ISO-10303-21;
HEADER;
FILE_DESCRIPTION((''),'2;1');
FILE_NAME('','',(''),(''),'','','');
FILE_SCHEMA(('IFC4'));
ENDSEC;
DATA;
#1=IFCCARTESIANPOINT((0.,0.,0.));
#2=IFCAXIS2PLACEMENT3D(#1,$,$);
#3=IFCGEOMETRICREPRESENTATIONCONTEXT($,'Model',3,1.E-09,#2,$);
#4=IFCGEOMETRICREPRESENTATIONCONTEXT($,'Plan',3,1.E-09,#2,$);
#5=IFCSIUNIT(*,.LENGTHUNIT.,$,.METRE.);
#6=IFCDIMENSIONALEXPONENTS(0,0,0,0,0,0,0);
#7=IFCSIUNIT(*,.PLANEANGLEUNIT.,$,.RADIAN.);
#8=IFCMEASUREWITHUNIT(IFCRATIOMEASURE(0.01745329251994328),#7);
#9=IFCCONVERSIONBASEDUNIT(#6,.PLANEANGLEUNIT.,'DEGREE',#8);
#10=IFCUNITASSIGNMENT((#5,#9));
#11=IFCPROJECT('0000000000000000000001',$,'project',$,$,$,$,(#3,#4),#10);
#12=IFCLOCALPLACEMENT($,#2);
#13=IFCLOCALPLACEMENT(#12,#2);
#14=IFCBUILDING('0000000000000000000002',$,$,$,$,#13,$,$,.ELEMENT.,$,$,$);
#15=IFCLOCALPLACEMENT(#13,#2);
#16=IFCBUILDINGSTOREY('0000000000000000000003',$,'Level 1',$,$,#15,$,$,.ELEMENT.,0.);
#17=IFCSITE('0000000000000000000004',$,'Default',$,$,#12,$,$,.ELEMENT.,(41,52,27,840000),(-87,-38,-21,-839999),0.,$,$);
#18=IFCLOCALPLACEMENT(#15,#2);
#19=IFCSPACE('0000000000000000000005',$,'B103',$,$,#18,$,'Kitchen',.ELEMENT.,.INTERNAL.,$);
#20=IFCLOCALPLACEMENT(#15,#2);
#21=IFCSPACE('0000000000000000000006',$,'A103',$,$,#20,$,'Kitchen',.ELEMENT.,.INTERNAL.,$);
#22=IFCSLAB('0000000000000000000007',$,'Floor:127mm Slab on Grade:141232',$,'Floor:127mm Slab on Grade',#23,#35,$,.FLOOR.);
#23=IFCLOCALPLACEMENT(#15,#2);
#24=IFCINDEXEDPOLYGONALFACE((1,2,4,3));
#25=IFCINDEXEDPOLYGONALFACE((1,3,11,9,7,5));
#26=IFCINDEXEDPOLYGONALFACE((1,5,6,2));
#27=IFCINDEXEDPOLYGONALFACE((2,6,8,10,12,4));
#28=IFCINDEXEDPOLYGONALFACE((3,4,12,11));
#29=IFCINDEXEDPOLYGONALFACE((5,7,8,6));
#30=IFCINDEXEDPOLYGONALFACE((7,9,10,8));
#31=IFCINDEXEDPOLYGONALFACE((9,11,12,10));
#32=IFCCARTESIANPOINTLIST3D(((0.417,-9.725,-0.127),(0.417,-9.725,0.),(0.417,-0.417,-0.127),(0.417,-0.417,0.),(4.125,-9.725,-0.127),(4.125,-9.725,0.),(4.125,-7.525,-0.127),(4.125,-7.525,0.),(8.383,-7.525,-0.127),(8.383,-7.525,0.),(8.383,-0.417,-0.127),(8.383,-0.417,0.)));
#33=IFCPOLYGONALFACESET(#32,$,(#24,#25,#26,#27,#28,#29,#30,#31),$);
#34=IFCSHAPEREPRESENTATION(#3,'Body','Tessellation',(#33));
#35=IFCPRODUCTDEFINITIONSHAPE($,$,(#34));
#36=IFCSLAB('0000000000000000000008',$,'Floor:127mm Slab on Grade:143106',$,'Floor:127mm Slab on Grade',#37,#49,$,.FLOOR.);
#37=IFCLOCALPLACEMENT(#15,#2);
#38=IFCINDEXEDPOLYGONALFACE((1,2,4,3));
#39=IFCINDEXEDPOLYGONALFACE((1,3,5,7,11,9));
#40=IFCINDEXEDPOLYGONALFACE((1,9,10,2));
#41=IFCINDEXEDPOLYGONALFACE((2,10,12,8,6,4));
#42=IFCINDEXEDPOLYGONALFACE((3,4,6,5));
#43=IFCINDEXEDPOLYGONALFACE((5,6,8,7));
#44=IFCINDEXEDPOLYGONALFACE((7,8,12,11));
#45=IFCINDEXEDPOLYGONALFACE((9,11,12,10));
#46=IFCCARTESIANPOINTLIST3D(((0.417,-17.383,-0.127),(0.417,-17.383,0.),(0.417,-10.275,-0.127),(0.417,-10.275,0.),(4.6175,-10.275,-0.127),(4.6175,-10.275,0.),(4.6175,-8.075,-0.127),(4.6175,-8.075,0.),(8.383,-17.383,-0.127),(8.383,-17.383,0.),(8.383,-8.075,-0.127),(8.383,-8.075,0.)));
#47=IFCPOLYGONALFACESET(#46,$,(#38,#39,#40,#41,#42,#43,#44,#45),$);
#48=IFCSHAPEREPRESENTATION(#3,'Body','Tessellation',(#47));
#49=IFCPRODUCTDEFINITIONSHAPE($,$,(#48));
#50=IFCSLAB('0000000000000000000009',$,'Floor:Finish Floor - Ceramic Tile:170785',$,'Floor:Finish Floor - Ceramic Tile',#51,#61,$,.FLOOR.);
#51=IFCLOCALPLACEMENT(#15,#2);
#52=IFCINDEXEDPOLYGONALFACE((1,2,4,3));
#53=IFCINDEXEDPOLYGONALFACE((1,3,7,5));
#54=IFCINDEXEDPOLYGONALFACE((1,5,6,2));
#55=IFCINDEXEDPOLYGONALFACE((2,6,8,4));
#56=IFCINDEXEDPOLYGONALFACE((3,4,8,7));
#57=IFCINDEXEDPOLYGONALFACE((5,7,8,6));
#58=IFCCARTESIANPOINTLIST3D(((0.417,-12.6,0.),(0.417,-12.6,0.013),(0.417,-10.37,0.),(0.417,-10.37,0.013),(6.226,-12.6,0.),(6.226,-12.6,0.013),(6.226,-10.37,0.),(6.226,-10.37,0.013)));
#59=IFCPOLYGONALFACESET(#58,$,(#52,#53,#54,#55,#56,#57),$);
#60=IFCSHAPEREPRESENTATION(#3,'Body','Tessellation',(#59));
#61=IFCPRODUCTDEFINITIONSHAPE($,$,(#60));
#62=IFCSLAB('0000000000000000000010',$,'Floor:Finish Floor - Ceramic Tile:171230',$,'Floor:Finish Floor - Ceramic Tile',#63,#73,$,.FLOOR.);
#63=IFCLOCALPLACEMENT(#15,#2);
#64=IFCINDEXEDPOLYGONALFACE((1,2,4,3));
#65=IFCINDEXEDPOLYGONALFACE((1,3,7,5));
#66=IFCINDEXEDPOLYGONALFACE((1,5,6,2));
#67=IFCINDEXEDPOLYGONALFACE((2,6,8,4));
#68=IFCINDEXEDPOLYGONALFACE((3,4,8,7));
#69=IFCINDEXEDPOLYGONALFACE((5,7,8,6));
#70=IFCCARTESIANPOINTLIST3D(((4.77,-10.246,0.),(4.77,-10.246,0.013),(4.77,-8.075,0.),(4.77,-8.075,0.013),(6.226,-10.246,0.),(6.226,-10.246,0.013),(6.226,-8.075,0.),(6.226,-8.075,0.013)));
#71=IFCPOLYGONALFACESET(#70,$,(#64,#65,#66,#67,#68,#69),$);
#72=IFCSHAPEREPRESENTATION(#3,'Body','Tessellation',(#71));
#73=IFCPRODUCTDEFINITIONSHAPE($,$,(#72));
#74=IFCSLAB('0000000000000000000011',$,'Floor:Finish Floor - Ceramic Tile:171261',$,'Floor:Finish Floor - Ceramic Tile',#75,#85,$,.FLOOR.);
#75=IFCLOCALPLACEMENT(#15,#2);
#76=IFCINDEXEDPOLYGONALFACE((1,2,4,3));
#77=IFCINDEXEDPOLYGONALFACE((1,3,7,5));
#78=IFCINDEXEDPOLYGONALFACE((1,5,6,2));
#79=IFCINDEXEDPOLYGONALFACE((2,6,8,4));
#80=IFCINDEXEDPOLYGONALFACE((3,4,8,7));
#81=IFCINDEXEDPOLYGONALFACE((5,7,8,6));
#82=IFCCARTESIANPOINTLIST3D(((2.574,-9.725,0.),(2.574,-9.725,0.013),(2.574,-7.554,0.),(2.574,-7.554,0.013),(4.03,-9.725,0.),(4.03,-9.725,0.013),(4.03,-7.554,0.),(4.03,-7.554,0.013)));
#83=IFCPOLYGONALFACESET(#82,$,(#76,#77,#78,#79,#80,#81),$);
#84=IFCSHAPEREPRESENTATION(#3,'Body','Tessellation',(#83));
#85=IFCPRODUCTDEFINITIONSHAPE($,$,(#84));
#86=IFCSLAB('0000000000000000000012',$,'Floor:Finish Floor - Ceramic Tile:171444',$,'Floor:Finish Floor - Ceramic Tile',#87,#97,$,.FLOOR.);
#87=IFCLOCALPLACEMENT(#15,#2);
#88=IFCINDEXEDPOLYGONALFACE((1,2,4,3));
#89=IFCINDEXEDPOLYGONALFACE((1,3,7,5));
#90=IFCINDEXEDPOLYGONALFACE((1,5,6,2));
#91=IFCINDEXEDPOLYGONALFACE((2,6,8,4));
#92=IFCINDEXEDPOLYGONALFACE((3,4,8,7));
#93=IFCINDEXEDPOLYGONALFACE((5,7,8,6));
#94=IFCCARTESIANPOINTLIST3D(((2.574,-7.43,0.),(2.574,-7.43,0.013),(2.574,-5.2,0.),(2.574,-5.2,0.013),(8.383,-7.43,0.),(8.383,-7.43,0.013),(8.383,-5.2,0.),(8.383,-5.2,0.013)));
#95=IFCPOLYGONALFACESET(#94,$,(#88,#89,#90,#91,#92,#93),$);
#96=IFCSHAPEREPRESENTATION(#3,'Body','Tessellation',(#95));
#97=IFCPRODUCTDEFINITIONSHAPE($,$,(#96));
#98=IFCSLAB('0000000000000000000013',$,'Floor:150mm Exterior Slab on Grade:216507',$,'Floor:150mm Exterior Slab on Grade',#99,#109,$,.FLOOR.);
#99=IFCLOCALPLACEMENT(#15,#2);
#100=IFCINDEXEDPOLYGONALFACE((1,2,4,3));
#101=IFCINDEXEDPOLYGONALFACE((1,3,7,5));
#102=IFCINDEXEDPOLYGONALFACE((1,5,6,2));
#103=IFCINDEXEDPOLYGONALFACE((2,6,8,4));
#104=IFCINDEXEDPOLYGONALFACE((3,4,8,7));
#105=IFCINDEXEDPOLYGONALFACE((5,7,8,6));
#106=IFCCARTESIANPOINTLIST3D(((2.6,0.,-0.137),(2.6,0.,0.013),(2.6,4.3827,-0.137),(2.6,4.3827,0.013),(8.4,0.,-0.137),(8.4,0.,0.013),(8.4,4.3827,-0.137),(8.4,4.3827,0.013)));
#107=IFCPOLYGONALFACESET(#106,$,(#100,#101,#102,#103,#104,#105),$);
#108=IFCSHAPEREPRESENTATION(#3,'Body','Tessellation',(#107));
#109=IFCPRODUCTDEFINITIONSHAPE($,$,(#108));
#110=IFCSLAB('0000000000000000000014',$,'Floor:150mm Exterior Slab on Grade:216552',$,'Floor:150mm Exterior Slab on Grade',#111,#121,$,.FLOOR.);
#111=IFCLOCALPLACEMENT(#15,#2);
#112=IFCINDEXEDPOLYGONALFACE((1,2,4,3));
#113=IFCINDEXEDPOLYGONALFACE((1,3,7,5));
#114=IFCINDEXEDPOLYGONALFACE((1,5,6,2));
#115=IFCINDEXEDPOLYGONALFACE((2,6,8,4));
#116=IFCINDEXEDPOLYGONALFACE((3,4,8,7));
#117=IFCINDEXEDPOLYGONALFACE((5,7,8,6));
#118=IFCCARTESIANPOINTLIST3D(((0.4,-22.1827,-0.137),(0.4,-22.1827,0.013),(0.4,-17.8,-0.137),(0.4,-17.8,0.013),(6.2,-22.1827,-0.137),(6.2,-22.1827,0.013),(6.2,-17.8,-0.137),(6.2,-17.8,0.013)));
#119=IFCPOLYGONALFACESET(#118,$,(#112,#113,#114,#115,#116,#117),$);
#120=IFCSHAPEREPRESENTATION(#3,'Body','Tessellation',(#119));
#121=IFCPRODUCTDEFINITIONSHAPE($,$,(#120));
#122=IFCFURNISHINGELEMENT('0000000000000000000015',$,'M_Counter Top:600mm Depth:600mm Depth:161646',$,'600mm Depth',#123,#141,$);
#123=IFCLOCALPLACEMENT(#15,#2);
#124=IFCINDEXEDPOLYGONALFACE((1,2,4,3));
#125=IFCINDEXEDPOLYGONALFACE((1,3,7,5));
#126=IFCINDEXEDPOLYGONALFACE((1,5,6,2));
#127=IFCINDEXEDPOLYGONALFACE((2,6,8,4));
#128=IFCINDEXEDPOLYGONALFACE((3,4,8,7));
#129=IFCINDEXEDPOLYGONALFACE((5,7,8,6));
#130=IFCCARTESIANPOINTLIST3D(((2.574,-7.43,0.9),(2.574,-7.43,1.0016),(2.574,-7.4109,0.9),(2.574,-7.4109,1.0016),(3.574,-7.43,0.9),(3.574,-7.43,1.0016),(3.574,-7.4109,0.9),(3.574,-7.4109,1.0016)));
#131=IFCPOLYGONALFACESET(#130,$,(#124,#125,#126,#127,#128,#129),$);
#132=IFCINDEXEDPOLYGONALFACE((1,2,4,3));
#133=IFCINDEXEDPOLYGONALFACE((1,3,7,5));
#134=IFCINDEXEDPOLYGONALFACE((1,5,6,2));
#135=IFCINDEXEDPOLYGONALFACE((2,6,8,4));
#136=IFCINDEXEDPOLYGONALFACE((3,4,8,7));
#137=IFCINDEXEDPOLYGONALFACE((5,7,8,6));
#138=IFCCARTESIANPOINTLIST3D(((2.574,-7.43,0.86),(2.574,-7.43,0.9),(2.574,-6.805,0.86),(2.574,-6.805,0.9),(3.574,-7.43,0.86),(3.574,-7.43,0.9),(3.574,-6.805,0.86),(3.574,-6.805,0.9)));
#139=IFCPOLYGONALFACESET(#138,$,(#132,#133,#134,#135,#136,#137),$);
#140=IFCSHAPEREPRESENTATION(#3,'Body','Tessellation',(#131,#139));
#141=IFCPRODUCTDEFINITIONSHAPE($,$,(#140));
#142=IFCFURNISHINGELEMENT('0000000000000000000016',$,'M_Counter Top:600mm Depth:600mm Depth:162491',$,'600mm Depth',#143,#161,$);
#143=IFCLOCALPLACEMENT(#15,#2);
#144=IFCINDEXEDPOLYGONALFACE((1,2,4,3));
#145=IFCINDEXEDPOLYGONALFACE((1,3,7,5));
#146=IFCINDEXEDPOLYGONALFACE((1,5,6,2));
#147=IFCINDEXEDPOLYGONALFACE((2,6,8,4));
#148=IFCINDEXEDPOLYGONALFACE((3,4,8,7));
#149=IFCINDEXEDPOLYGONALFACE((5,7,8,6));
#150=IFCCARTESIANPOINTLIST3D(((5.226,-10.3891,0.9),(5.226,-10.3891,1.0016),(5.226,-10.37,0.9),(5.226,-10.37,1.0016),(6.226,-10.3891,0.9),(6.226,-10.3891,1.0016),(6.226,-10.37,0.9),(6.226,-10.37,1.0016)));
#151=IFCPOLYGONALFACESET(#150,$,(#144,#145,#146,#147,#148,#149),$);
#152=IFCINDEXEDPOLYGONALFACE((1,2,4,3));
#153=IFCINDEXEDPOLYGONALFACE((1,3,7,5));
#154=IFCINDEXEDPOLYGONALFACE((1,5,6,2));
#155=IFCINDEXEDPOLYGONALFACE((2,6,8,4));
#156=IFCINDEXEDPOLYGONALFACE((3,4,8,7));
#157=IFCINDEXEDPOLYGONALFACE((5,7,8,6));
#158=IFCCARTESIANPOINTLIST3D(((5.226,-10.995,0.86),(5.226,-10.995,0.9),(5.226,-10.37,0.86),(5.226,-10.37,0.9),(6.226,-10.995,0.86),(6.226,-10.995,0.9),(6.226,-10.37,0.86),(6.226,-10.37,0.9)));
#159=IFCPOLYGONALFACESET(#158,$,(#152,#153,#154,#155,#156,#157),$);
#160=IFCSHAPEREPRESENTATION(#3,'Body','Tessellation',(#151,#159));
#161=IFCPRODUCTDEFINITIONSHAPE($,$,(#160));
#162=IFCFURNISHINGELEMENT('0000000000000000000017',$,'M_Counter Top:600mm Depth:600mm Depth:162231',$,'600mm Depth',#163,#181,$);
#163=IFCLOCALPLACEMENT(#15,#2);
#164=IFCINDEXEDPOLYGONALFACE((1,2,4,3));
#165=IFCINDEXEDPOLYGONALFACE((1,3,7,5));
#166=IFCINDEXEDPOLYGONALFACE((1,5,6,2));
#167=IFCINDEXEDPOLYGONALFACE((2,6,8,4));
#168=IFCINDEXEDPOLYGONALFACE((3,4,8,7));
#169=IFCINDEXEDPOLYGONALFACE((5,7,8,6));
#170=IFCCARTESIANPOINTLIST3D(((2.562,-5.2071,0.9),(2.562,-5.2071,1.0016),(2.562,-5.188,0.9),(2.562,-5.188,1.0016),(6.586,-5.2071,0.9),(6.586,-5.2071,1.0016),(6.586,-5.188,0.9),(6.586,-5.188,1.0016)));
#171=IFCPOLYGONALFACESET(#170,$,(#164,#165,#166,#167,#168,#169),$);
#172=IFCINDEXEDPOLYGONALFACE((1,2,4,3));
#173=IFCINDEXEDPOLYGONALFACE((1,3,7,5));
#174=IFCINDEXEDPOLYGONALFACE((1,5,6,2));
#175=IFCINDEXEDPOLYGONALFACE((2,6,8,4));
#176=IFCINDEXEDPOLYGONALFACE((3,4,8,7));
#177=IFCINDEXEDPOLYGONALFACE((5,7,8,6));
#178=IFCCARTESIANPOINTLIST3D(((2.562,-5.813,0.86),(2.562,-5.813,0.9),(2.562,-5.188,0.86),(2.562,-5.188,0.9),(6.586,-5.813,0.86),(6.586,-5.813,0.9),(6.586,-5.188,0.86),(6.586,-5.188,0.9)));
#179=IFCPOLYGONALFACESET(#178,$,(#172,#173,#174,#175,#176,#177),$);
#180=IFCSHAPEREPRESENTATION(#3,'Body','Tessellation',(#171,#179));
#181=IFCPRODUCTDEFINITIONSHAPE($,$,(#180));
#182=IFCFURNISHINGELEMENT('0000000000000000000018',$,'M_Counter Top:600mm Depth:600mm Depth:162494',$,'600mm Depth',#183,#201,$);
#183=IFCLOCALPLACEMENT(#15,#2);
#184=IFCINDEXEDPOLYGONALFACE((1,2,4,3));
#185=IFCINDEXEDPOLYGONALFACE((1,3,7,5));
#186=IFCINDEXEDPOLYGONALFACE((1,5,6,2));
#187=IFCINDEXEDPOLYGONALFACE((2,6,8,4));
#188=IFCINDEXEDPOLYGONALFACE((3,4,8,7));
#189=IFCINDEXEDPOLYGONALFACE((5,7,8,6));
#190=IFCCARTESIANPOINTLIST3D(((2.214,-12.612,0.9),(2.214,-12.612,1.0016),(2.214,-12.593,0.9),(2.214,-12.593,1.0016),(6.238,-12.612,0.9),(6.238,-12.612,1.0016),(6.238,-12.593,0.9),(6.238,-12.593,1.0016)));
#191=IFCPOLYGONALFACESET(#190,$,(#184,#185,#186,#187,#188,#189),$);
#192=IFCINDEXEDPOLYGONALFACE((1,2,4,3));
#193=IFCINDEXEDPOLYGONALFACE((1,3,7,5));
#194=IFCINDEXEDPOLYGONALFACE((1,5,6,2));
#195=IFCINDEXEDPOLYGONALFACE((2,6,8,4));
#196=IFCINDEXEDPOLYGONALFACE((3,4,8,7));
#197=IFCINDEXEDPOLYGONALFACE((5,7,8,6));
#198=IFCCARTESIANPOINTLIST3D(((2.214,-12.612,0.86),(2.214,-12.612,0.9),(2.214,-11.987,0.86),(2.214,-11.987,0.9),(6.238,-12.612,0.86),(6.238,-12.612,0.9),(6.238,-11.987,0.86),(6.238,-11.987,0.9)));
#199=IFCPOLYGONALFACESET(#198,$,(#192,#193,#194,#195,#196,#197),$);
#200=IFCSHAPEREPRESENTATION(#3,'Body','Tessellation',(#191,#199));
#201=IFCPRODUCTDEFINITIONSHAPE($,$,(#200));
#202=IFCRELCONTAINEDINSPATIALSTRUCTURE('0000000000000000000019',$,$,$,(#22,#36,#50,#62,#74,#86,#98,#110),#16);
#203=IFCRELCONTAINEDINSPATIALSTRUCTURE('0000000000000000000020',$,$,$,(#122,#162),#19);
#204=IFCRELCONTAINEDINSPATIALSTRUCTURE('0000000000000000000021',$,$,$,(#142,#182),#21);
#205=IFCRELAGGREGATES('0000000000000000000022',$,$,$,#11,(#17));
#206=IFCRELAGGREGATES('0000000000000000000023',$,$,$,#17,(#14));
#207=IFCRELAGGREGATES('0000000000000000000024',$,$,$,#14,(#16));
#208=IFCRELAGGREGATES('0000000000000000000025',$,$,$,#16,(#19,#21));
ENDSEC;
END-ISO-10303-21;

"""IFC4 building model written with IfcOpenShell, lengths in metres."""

from ifc_helpers import new_model, entity, si_unit, converted_unit, frame, frame_2d, origin, origin_2d_with_axis, place, context, project, spatial, polyline, rectangle, outline, extrude, source, transform, mapped, element, save


model = new_model("IFC4")

# Units and contexts
model_context = context("Model", 3, precision=1e-09, world=origin())
plan_context = context("Plan", 3, precision=1e-09, world=origin())
ifc_project = project(units=[si_unit("LENGTHUNIT", "METRE"), converted_unit("PLANEANGLEUNIT", "DEGREE", entity("IfcRatioMeasure", 0.01745329251994328), si_unit("PLANEANGLEUNIT", "RADIAN"), dimensions=[0, 0, 0, 0, 0, 0, 0])], contexts=[model_context, plan_context])

# Site, building, storey
site_placement = place(None, origin())
site = spatial("IfcSite", under=ifc_project, at=site_placement, Name="Default", CompositionType="ELEMENT", RefLatitude=(41, 52, 27, 840000), RefLongitude=(-87, -38, -21, -839999), RefElevation=0.0)
building_placement = place(site_placement, origin())
building = spatial("IfcBuilding", under=site, at=building_placement, CompositionType="ELEMENT")
storey_placement = place(building_placement, origin())
storey = spatial("IfcBuildingStorey", under=building, at=storey_placement, Name="Level 1", CompositionType="ELEMENT", Elevation=0.0)

# Slabs
slab_1_placement = place(storey_placement, frame((0.417, -9.725, -0.127)))
element("IfcSlab", 1, at=slab_1_placement, inside=storey, Name="Floor:127mm Slab on Grade:141232", ObjectType="Floor:127mm Slab on Grade", PredefinedType="FLOOR", context=model_context, shape_type="SweptSolid", body=[
    extrude(outline(polyline([(-3.983, 4.654), (-3.983, -2.454), (0.275, -2.454), (0.275, -4.654), (3.983, -4.654), (3.983, 4.654), (-3.983, 4.654)])), frame((3.983, 4.654, 0.127), z_axis=(0.0, 0.0, -1.0), x_axis=(-1.0, 0.0, 0.0)), (0.0, 0.0, 1.0), 0.127),
])
slab_2_placement = place(storey_placement, frame((0.417, -17.383, -0.127)))
element("IfcSlab", 2, at=slab_2_placement, inside=storey, Name="Floor:127mm Slab on Grade:143106", ObjectType="Floor:127mm Slab on Grade", PredefinedType="FLOOR", context=model_context, shape_type="SweptSolid", body=[
    extrude(outline(polyline([(-3.983, 4.654), (-3.983, -4.654), (3.983, -4.654), (3.983, 2.454), (-0.2175, 2.454), (-0.2175, 4.654), (-3.983, 4.654)])), frame((3.983, 4.654, 0.127), z_axis=(0.0, 0.0, -1.0), x_axis=(-1.0, 0.0, 0.0)), (0.0, 0.0, 1.0), 0.127),
])
slab_3_placement = place(storey_placement, frame((0.417, -12.6, 0.0)))
element("IfcSlab", 3, at=slab_3_placement, inside=storey, Name="Floor:Finish Floor - Ceramic Tile:170785", ObjectType="Floor:Finish Floor - Ceramic Tile", PredefinedType="FLOOR", context=model_context, shape_type="SweptSolid", body=[
    extrude(rectangle(XDim=5.809, YDim=2.23, at=frame_2d((0.0, 0.0), x_axis=(-1.0, 0.0))), frame((2.9045, 1.115, 0.013), z_axis=(0.0, 0.0, -1.0), x_axis=(-1.0, 0.0, 0.0)), (0.0, 0.0, 1.0), 0.013),
])
slab_4_placement = place(storey_placement, frame((4.77, -10.246, 0.0)))
element("IfcSlab", 4, at=slab_4_placement, inside=storey, Name="Floor:Finish Floor - Ceramic Tile:171230", ObjectType="Floor:Finish Floor - Ceramic Tile", PredefinedType="FLOOR", context=model_context, shape_type="SweptSolid", body=[
    extrude(rectangle(XDim=1.456, YDim=2.171, at=frame_2d((0.0, 0.0), x_axis=(-1.0, 0.0))), frame((0.728, 1.0855, 0.013), z_axis=(0.0, 0.0, -1.0), x_axis=(-1.0, 0.0, 0.0)), (0.0, 0.0, 1.0), 0.013),
])
slab_5_placement = place(storey_placement, frame((2.574, -9.725, 0.0)))
element("IfcSlab", 5, at=slab_5_placement, inside=storey, Name="Floor:Finish Floor - Ceramic Tile:171261", ObjectType="Floor:Finish Floor - Ceramic Tile", PredefinedType="FLOOR", context=model_context, shape_type="SweptSolid", body=[
    extrude(rectangle(XDim=2.171, YDim=1.456, at=frame_2d((0.0, 0.0), x_axis=(0.0, -1.0))), frame((0.728, 1.0855, 0.013), z_axis=(0.0, 0.0, -1.0), x_axis=(-1.0, 0.0, 0.0)), (0.0, 0.0, 1.0), 0.013),
])
slab_6_placement = place(storey_placement, frame((2.574, -7.43, 0.0)))
element("IfcSlab", 6, at=slab_6_placement, inside=storey, Name="Floor:Finish Floor - Ceramic Tile:171444", ObjectType="Floor:Finish Floor - Ceramic Tile", PredefinedType="FLOOR", context=model_context, shape_type="SweptSolid", body=[
    extrude(rectangle(XDim=5.809, YDim=2.23, at=frame_2d((0.0, 0.0), x_axis=(-1.0, 0.0))), frame((2.9045, 1.115, 0.013), z_axis=(0.0, 0.0, -1.0), x_axis=(-1.0, 0.0, 0.0)), (0.0, 0.0, 1.0), 0.013),
])
slab_7_placement = place(storey_placement, frame((2.6, 0.0, -0.137)))
element("IfcSlab", 7, at=slab_7_placement, inside=storey, Name="Floor:150mm Exterior Slab on Grade:216507", ObjectType="Floor:150mm Exterior Slab on Grade", PredefinedType="FLOOR", context=model_context, shape_type="SweptSolid", body=[
    extrude(rectangle(XDim=5.8, YDim=4.3827, at=frame_2d((0.0, 0.0), x_axis=(-1.0, 0.0))), frame((2.9, 2.1914, 0.15), z_axis=(0.0, 0.0, -1.0), x_axis=(-1.0, 0.0, 0.0)), (0.0, 0.0, 1.0), 0.15),
])
slab_8_placement = place(storey_placement, frame((0.4, -22.1827, -0.137)))
element("IfcSlab", 8, at=slab_8_placement, inside=storey, Name="Floor:150mm Exterior Slab on Grade:216552", ObjectType="Floor:150mm Exterior Slab on Grade", PredefinedType="FLOOR", context=model_context, shape_type="SweptSolid", body=[
    extrude(rectangle(XDim=5.8, YDim=4.3827, at=origin_2d_with_axis()), frame((2.9, 2.1914, 0.15), z_axis=(0.0, 0.0, -1.0), x_axis=(-1.0, 0.0, 0.0)), (0.0, 0.0, 1.0), 0.15),
])

# Shared definitions
space_1_placement = place(storey_placement, origin())
space_1 = spatial("IfcSpace", under=storey, at=space_1_placement, Name="B103", LongName="Kitchen", CompositionType="ELEMENT", PredefinedType="INTERNAL")

# Furnishing element
shared_shape_1 = source(origin(), model_context, "Body", "SweptSolid", [
    extrude(rectangle(XDim=0.0191, YDim=1.0, at=origin_2d_with_axis()), frame((-0.7005, -0.0095, 0.9), z_axis=(0.0, 0.0, 1.0), x_axis=(0.0, -1.0, 0.0)), (0.0, 0.0, 1.0), 0.1016),
    extrude(rectangle(XDim=1.0, YDim=0.625, at=origin_2d_with_axis()), frame((-0.7005, -0.3125, 0.86), z_axis=(0.0, 0.0, 1.0), x_axis=(-1.0, 0.0, 0.0)), (0.0, 0.0, 1.0), 0.04),
])
furnishing_1_placement = place(space_1_placement, frame((2.3735, -7.43, 0.0), z_axis=(0.0, 0.0, 1.0), x_axis=(-1.0, 0.0, 0.0)))
element("IfcFurnishingElement", 9, at=furnishing_1_placement, inside=space_1, Name="M_Counter Top:600mm Depth:600mm Depth:161646", ObjectType="600mm Depth", context=model_context, shape_type="MappedRepresentation", body=[
    mapped(shared_shape_1, transform((0.0, 0.0, 0.0), scale=1.0)),
])

# Shared definitions
space_2_placement = place(storey_placement, origin())
space_2 = spatial("IfcSpace", under=storey, at=space_2_placement, Name="A103", LongName="Kitchen", CompositionType="ELEMENT", PredefinedType="INTERNAL")

# Furnishing elements
furnishing_2_placement = place(space_2_placement, frame((6.4265, -10.37, 0.0)))
element("IfcFurnishingElement", 10, at=furnishing_2_placement, inside=space_2, Name="M_Counter Top:600mm Depth:600mm Depth:162491", ObjectType="600mm Depth", context=model_context, shape_type="MappedRepresentation", body=[
    mapped(shared_shape_1, transform((0.0, 0.0, 0.0), scale=1.0)),
])
shared_shape_2 = source(origin(), model_context, "Body", "SweptSolid", [
    extrude(rectangle(XDim=0.0191, YDim=4.024, at=origin_2d_with_axis()), frame((0.8115, -0.0095, 0.9), z_axis=(0.0, 0.0, 1.0), x_axis=(0.0, -1.0, 0.0)), (0.0, 0.0, 1.0), 0.1016),
    extrude(rectangle(XDim=4.024, YDim=0.625, at=origin_2d_with_axis()), frame((0.8115, -0.3125, 0.86), z_axis=(0.0, 0.0, 1.0), x_axis=(-1.0, 0.0, 0.0)), (0.0, 0.0, 1.0), 0.04),
])
furnishing_3_placement = place(space_1_placement, frame((3.7625, -5.188, 0.0)))
element("IfcFurnishingElement", 11, at=furnishing_3_placement, inside=space_1, Name="M_Counter Top:600mm Depth:600mm Depth:162231", ObjectType="600mm Depth", context=model_context, shape_type="MappedRepresentation", body=[
    mapped(shared_shape_2, transform((0.0, 0.0, 0.0), scale=1.0)),
])
furnishing_4_placement = place(space_2_placement, frame((5.0375, -12.612, 0.0), z_axis=(0.0, 0.0, 1.0), x_axis=(-1.0, 0.0, 0.0)))
element("IfcFurnishingElement", 12, at=furnishing_4_placement, inside=space_2, Name="M_Counter Top:600mm Depth:600mm Depth:162494", ObjectType="600mm Depth", context=model_context, shape_type="MappedRepresentation", body=[
    mapped(shared_shape_2, transform((0.0, 0.0, 0.0), scale=1.0)),
])

save(model, "model.ifc")
